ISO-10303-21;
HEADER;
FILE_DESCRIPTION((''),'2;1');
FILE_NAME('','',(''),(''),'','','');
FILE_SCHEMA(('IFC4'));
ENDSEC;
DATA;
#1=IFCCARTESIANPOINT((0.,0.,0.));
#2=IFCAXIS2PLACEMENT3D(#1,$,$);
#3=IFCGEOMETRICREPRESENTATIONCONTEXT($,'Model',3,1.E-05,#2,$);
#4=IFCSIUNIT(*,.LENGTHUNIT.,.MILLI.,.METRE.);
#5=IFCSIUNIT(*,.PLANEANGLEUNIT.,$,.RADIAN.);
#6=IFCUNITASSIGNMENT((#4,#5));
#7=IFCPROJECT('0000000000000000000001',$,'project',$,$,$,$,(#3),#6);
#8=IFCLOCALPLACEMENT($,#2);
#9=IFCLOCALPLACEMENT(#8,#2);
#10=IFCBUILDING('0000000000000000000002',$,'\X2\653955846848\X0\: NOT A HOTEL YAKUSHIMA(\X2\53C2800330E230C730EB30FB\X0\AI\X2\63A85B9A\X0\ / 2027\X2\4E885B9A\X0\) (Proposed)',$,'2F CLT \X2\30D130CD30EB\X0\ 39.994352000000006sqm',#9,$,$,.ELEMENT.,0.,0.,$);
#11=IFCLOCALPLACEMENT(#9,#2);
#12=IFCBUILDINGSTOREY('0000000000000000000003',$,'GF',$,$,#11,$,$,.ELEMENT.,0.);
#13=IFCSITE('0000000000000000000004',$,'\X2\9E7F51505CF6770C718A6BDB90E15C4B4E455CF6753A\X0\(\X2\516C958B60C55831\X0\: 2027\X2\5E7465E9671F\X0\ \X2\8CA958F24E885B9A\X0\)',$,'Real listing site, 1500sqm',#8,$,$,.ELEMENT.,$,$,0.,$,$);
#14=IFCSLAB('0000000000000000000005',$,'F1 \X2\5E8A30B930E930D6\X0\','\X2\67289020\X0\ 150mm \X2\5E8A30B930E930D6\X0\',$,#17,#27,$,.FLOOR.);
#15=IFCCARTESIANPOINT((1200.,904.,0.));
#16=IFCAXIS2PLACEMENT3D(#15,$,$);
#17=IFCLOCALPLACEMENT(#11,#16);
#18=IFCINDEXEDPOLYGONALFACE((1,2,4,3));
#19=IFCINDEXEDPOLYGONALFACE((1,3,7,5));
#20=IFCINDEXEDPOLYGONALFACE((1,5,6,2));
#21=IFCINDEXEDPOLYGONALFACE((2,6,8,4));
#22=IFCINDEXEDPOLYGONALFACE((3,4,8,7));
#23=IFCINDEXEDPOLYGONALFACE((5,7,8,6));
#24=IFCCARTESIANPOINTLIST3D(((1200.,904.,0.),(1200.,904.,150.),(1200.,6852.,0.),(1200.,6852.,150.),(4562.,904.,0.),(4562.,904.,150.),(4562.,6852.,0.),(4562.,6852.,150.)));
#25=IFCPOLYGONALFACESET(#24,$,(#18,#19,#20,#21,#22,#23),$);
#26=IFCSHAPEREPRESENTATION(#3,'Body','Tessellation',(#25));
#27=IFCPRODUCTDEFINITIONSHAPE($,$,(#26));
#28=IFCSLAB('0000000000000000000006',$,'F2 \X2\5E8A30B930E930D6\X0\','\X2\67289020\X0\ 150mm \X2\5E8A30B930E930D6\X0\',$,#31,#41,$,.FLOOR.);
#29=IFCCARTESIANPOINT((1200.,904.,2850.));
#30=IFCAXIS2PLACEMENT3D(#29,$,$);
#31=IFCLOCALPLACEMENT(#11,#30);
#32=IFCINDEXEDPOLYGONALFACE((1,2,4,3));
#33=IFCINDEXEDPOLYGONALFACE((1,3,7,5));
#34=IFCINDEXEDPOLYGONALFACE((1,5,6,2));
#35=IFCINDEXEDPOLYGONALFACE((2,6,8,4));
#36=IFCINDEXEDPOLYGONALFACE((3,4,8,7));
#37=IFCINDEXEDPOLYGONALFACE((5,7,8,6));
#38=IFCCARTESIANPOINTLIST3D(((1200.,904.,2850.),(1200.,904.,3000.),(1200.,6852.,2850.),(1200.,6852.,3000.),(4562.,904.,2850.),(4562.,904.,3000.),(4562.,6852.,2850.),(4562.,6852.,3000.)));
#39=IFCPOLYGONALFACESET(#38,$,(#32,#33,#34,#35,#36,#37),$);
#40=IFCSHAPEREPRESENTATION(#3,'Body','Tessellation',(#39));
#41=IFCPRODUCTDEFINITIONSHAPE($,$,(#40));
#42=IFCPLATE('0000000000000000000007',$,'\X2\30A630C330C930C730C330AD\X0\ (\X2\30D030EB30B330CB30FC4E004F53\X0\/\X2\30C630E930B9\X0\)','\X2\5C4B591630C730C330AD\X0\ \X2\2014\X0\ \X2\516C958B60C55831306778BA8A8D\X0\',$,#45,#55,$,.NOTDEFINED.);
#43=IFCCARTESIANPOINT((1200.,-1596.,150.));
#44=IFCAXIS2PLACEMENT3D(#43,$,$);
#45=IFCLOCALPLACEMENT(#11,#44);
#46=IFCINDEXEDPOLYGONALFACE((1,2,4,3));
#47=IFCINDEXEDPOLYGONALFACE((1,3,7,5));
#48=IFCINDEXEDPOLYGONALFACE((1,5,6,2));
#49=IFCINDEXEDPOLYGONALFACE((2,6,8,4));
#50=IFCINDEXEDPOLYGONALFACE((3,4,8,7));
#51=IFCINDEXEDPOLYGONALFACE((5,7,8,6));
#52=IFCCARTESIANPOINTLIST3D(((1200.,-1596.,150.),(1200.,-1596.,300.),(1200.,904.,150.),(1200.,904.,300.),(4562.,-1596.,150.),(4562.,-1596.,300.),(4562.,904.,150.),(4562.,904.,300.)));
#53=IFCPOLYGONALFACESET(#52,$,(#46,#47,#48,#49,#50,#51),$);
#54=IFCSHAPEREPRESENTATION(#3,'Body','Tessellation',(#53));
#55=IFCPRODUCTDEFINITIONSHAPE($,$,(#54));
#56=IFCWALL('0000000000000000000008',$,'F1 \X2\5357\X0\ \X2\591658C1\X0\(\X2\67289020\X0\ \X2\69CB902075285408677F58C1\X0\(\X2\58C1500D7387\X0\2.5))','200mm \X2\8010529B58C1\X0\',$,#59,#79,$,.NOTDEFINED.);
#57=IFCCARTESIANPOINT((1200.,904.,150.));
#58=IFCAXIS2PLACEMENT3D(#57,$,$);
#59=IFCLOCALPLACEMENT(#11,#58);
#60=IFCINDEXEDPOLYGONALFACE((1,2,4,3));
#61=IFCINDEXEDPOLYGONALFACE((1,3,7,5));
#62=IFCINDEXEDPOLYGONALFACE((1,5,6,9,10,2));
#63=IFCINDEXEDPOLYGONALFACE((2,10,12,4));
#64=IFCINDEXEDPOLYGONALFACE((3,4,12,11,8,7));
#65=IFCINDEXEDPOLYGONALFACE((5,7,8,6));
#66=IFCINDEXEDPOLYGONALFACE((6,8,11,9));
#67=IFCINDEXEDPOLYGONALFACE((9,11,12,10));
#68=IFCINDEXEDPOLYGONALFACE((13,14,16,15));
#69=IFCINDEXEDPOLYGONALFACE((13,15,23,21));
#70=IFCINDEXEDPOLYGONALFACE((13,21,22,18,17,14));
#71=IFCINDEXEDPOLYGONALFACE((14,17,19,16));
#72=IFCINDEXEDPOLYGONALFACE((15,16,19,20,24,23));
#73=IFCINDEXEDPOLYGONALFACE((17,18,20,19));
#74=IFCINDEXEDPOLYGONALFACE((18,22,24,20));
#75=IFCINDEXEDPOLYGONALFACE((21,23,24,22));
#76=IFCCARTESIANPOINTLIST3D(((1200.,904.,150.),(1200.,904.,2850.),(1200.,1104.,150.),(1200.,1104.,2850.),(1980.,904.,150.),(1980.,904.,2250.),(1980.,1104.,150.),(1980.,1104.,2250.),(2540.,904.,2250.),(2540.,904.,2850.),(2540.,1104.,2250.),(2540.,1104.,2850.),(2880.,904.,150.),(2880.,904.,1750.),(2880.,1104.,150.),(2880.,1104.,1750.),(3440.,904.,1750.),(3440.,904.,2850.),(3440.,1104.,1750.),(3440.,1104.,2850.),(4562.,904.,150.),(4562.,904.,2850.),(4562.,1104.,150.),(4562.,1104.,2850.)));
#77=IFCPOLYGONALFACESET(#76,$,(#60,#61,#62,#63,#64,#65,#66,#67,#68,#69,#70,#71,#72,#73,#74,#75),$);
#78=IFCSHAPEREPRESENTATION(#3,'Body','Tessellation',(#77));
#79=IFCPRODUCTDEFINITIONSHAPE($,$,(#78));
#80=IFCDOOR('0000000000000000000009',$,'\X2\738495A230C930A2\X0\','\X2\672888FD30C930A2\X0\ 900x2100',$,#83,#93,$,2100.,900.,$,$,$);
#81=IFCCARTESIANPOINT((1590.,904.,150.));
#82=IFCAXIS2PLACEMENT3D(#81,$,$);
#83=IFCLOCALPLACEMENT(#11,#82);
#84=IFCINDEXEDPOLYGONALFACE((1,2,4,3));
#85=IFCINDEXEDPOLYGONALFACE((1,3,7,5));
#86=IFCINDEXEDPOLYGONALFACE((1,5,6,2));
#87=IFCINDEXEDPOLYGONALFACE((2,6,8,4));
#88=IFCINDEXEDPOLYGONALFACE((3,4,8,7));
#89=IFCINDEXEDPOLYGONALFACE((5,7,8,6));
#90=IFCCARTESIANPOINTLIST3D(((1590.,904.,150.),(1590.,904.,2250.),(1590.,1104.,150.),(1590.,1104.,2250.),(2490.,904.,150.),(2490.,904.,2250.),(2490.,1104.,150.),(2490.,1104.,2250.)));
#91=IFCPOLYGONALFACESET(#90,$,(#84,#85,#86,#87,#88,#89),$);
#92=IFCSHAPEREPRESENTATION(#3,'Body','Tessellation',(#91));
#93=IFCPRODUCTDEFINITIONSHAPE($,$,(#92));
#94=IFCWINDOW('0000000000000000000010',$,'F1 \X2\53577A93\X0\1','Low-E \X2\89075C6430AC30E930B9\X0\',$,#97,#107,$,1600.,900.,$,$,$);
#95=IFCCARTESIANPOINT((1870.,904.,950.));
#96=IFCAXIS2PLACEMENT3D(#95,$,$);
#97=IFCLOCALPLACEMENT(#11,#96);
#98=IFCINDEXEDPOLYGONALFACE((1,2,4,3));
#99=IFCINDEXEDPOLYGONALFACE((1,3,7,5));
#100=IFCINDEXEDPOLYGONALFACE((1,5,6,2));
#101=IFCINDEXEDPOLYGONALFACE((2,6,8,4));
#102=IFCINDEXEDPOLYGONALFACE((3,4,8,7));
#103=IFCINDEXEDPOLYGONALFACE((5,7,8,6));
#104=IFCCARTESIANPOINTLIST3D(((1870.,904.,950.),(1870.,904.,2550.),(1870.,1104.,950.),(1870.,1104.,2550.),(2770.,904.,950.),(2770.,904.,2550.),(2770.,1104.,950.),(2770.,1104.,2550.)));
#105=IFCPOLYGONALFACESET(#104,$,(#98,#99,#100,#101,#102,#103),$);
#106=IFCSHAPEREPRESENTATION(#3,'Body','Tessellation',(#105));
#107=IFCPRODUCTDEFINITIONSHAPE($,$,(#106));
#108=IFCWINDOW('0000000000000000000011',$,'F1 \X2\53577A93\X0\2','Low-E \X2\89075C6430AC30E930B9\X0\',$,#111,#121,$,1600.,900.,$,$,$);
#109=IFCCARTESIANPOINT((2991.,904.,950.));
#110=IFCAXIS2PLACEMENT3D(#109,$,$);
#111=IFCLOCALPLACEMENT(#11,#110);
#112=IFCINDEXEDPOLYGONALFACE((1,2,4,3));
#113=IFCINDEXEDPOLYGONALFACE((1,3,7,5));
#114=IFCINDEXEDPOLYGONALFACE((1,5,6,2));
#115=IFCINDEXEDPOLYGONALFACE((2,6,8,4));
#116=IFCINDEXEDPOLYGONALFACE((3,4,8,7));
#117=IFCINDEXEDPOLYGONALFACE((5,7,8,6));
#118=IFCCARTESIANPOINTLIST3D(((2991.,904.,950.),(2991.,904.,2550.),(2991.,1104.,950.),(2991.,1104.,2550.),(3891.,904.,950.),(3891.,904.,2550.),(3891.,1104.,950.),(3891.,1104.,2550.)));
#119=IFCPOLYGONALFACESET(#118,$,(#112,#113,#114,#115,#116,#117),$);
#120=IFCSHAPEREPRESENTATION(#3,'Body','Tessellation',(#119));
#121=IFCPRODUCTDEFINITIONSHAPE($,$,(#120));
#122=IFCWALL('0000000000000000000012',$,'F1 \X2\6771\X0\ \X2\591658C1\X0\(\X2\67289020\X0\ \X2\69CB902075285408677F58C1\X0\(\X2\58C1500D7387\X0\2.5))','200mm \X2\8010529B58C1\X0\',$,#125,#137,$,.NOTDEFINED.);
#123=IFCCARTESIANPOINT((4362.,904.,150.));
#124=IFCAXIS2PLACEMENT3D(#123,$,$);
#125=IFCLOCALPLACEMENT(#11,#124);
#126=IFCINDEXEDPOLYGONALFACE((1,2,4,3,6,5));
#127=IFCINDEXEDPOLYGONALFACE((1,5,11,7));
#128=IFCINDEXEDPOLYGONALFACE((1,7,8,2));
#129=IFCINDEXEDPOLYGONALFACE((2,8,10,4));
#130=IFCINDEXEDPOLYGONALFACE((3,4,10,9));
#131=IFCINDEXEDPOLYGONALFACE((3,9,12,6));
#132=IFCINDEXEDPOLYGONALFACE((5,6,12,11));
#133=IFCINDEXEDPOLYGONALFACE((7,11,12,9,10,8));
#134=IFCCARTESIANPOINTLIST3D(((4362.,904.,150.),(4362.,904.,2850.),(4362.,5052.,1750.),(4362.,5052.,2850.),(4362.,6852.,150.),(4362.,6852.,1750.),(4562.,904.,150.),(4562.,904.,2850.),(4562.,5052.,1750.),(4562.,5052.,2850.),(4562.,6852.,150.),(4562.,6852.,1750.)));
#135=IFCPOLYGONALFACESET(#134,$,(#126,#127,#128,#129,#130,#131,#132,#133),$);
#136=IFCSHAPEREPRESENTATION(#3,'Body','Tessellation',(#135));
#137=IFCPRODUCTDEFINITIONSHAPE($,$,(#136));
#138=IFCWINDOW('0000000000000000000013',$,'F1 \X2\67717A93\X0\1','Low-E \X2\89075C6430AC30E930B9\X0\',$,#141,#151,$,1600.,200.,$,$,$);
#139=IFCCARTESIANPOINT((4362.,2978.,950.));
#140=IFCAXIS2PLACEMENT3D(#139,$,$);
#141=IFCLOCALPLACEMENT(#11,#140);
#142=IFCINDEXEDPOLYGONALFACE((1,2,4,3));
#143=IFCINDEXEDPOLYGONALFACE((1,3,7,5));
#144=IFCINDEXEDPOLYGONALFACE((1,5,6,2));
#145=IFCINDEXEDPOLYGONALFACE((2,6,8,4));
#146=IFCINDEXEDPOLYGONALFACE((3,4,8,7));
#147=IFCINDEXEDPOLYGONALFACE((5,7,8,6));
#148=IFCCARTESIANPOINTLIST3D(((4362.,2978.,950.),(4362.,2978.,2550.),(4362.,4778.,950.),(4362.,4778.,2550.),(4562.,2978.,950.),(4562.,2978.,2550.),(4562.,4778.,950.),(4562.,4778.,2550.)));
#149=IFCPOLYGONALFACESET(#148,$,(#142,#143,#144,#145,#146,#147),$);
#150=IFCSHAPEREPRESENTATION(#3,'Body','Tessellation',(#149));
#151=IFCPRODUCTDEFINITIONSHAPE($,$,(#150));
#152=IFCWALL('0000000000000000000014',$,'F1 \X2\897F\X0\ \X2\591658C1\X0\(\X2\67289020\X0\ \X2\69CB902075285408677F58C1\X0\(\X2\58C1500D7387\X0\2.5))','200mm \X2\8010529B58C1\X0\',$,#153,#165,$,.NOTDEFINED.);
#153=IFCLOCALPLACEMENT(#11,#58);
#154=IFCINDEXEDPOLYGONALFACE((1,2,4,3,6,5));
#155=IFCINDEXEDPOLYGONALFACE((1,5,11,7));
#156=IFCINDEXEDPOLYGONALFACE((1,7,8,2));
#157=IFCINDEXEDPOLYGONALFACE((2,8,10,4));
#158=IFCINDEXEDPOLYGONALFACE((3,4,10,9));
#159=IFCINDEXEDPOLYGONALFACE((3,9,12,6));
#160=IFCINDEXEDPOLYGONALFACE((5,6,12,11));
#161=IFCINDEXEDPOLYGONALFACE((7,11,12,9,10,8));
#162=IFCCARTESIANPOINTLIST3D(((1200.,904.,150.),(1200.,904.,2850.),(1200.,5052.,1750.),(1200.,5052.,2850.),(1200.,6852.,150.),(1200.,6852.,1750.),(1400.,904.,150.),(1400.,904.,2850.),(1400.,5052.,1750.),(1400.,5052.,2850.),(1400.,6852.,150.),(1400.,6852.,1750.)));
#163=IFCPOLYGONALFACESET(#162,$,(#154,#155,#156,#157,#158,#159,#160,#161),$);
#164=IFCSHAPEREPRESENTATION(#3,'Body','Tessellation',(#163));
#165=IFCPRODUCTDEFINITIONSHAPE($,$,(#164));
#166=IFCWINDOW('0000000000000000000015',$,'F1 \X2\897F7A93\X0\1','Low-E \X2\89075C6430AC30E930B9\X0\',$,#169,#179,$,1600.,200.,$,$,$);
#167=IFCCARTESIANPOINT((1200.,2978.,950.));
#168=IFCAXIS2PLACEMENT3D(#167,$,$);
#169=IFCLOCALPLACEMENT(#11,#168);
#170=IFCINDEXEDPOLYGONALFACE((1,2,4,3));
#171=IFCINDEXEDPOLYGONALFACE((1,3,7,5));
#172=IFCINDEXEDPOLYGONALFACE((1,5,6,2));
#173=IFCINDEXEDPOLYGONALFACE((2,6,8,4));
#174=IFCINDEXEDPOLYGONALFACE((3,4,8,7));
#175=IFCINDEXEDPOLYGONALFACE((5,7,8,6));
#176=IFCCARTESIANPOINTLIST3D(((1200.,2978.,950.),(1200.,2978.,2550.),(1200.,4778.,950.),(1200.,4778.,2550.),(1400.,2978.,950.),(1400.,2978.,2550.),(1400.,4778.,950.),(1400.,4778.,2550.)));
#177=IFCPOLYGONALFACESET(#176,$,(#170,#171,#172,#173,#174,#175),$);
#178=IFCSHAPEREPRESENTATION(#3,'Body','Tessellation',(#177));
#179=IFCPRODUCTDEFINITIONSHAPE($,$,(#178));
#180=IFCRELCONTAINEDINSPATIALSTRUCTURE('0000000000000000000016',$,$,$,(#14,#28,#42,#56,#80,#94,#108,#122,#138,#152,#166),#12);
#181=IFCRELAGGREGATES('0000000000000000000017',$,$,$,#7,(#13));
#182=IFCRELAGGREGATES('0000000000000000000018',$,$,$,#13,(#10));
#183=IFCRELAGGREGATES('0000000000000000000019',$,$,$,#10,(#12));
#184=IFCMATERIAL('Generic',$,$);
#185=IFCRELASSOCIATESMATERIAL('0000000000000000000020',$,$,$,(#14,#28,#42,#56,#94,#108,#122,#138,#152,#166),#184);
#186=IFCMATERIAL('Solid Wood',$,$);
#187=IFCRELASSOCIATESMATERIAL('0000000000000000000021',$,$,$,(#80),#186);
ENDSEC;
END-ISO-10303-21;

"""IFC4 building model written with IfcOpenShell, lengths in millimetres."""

from ifc_helpers import new_model, si_unit, frame, frame_2d, origin, place, context, project, spatial, rectangle, extrude, material, element, fill, save


model = new_model("IFC4")

# Units and contexts
model_context = context("Model", 3, precision=1e-05, world=origin())
ifc_project = project(units=[si_unit("LENGTHUNIT", "METRE", prefix="MILLI"), si_unit("PLANEANGLEUNIT", "RADIAN")], contexts=[model_context])

# Site, building, storey
site_placement = place(None, origin())
site = spatial("IfcSite", under=ifc_project, at=site_placement, Name="鹿児島県熊毛郡屋久島町(公開情報: 2027年早期 販売予定)", ObjectType="Real listing site, 1500sqm", CompositionType="ELEMENT", RefElevation=0.0)
building_placement = place(site_placement, origin())
building = spatial("IfcBuilding", under=site, at=building_placement, Name="改善案: NOT A HOTEL YAKUSHIMA(参考モデル・AI推定 / 2027予定) (Proposed)", ObjectType="2F CLT パネル 39.994352000000006sqm", CompositionType="ELEMENT", ElevationOfRefHeight=0.0, ElevationOfTerrain=0.0)
storey_placement = place(building_placement, origin())
storey = spatial("IfcBuildingStorey", under=building, at=storey_placement, Name="GF", CompositionType="ELEMENT", Elevation=0.0)

# Slabs
ifc_material_1 = material(Name="Generic")
slab_1_placement = place(storey_placement, frame((1200.0, 904.0, 0.0)))
element("IfcSlab", 1, at=slab_1_placement, inside=storey, material=ifc_material_1, Name="F1 床スラブ", Description="木造 150mm 床スラブ", PredefinedType="FLOOR", context=model_context, shape_type="SweptSolid", body=[
    extrude(rectangle(XDim=3362.0, YDim=5948.0, at=frame_2d((1681.0, 2974.0))), frame((1200.0, 904.0, 0.0)), (0.0, 0.0, 1.0), 150.0),
])
slab_2_placement = place(storey_placement, frame((1200.0, 904.0, 2850.0)))
element("IfcSlab", 2, at=slab_2_placement, inside=storey, material=ifc_material_1, Name="F2 床スラブ", Description="木造 150mm 床スラブ", PredefinedType="FLOOR", context=model_context, shape_type="SweptSolid", body=[
    extrude(rectangle(XDim=3362.0, YDim=5948.0, at=frame_2d((1681.0, 2974.0))), frame((1200.0, 904.0, 2850.0)), (0.0, 0.0, 1.0), 150.0),
])

# Plate
plate_placement = place(storey_placement, frame((1200.0, -1596.0, 150.0)))
element("IfcPlate", 3, at=plate_placement, inside=storey, material=ifc_material_1, Name="ウッドデッキ (バルコニー一体/テラス)", Description="屋外デッキ — 公開情報で確認", PredefinedType="NOTDEFINED", context=model_context, shape_type="SweptSolid", body=[
    extrude(rectangle(XDim=3362.0, YDim=2500.0, at=frame_2d((1681.0, 1250.0))), frame((1200.0, -1596.0, 150.0)), (0.0, 0.0, 1.0), 150.0),
])

# Wall, openings, door, windows
wall_1_placement = place(storey_placement, frame((1200.0, 904.0, 150.0)))
wall_1 = element("IfcWall", 4, at=wall_1_placement, inside=storey, material=ifc_material_1, Name="F1 南 外壁(木造 構造用合板壁(壁倍率2.5))", Description="200mm 耐力壁", PredefinedType="NOTDEFINED", context=model_context, shape_type="SweptSolid", body=[
    extrude(rectangle(XDim=3362.0, YDim=200.0, at=frame_2d((1681.0, 100.0))), frame((1200.0, 904.0, 150.0)), (0.0, 0.0, 1.0), 2700.0),
])
opening_1_placement = place(storey_placement, frame((1590.0, 904.0, 150.0)))
opening_1 = element("IfcOpeningElement", 5, at=opening_1_placement, cuts=wall_1, PredefinedType="NOTDEFINED", context=model_context, shape_type="SweptSolid", body=[
    extrude(rectangle(XDim=900.0, YDim=200.0, at=frame_2d((450.0, 100.0))), frame((1590.0, 904.0, 150.0)), (0.0, 0.0, 1.0), 2100.0),
])
opening_2_placement = place(storey_placement, frame((1870.0, 904.0, 950.0)))
opening_2 = element("IfcOpeningElement", 6, at=opening_2_placement, cuts=wall_1, PredefinedType="NOTDEFINED", context=model_context, shape_type="SweptSolid", body=[
    extrude(rectangle(XDim=900.0, YDim=200.0, at=frame_2d((450.0, 100.0))), frame((1870.0, 904.0, 950.0)), (0.0, 0.0, 1.0), 1600.0),
])
opening_3_placement = place(storey_placement, frame((2991.0, 904.0, 950.0)))
opening_3 = element("IfcOpeningElement", 7, at=opening_3_placement, cuts=wall_1, PredefinedType="NOTDEFINED", context=model_context, shape_type="SweptSolid", body=[
    extrude(rectangle(XDim=900.0, YDim=200.0, at=frame_2d((450.0, 100.0))), frame((2991.0, 904.0, 950.0)), (0.0, 0.0, 1.0), 1600.0),
])
ifc_material_2 = material(Name="Solid Wood")
door_placement = place(storey_placement, frame((1590.0, 904.0, 150.0)))
door = element("IfcDoor", 8, at=door_placement, inside=storey, material=ifc_material_2, Name="玄関ドア", Description="木製ドア 900x2100", OverallHeight=2100.0, OverallWidth=900.0, context=model_context, shape_type="SweptSolid", body=[
    extrude(rectangle(XDim=900.0, YDim=200.0, at=frame_2d((450.0, 100.0))), frame((1590.0, 904.0, 150.0)), (0.0, 0.0, 1.0), 2100.0),
])
fill(opening_1, door)
window_1_placement = place(storey_placement, frame((1870.0, 904.0, 950.0)))
window_1 = element("IfcWindow", 9, at=window_1_placement, inside=storey, material=ifc_material_1, Name="F1 南窓1", Description="Low-E 複層ガラス", OverallHeight=1600.0, OverallWidth=900.0, context=model_context, shape_type="SweptSolid", body=[
    extrude(rectangle(XDim=900.0, YDim=200.0, at=frame_2d((450.0, 100.0))), frame((1870.0, 904.0, 950.0)), (0.0, 0.0, 1.0), 1600.0),
])
fill(opening_2, window_1)
window_2_placement = place(storey_placement, frame((2991.0, 904.0, 950.0)))
window_2 = element("IfcWindow", 10, at=window_2_placement, inside=storey, material=ifc_material_1, Name="F1 南窓2", Description="Low-E 複層ガラス", OverallHeight=1600.0, OverallWidth=900.0, context=model_context, shape_type="SweptSolid", body=[
    extrude(rectangle(XDim=900.0, YDim=200.0, at=frame_2d((450.0, 100.0))), frame((2991.0, 904.0, 950.0)), (0.0, 0.0, 1.0), 1600.0),
])
fill(opening_3, window_2)

# Walls, openings, windows
wall_2_placement = place(storey_placement, frame((4362.0, 904.0, 150.0)))
wall_2 = element("IfcWall", 11, at=wall_2_placement, inside=storey, material=ifc_material_1, Name="F1 東 外壁(木造 構造用合板壁(壁倍率2.5))", Description="200mm 耐力壁", PredefinedType="NOTDEFINED", context=model_context, shape_type="SweptSolid", body=[
    extrude(rectangle(XDim=200.0, YDim=5948.0, at=frame_2d((100.0, 2974.0))), frame((4362.0, 904.0, 150.0)), (0.0, 0.0, 1.0), 2700.0),
])
opening_4_placement = place(storey_placement, frame((4362.0, 2978.0, 950.0)))
opening_4 = element("IfcOpeningElement", 12, at=opening_4_placement, cuts=wall_2, PredefinedType="NOTDEFINED", context=model_context, shape_type="SweptSolid", body=[
    extrude(rectangle(XDim=200.0, YDim=1800.0, at=frame_2d((100.0, 900.0))), frame((4362.0, 2978.0, 950.0)), (0.0, 0.0, 1.0), 1600.0),
])
window_3_placement = place(storey_placement, frame((4362.0, 2978.0, 950.0)))
window_3 = element("IfcWindow", 13, at=window_3_placement, inside=storey, material=ifc_material_1, Name="F1 東窓1", Description="Low-E 複層ガラス", OverallHeight=1600.0, OverallWidth=200.0, context=model_context, shape_type="SweptSolid", body=[
    extrude(rectangle(XDim=200.0, YDim=1800.0, at=frame_2d((100.0, 900.0))), frame((4362.0, 2978.0, 950.0)), (0.0, 0.0, 1.0), 1600.0),
])
fill(opening_4, window_3)
wall_3_placement = place(storey_placement, frame((1200.0, 904.0, 150.0)))
wall_3 = element("IfcWall", 14, at=wall_3_placement, inside=storey, material=ifc_material_1, Name="F1 西 外壁(木造 構造用合板壁(壁倍率2.5))", Description="200mm 耐力壁", PredefinedType="NOTDEFINED", context=model_context, shape_type="SweptSolid", body=[
    extrude(rectangle(XDim=200.0, YDim=5948.0, at=frame_2d((100.0, 2974.0))), frame((1200.0, 904.0, 150.0)), (0.0, 0.0, 1.0), 2700.0),
])
opening_5_placement = place(storey_placement, frame((1200.0, 2978.0, 950.0)))
opening_5 = element("IfcOpeningElement", 15, at=opening_5_placement, cuts=wall_3, PredefinedType="NOTDEFINED", context=model_context, shape_type="SweptSolid", body=[
    extrude(rectangle(XDim=200.0, YDim=1800.0, at=frame_2d((100.0, 900.0))), frame((1200.0, 2978.0, 950.0)), (0.0, 0.0, 1.0), 1600.0),
])
window_4_placement = place(storey_placement, frame((1200.0, 2978.0, 950.0)))
window_4 = element("IfcWindow", 16, at=window_4_placement, inside=storey, material=ifc_material_1, Name="F1 西窓1", Description="Low-E 複層ガラス", OverallHeight=1600.0, OverallWidth=200.0, context=model_context, shape_type="SweptSolid", body=[
    extrude(rectangle(XDim=200.0, YDim=1800.0, at=frame_2d((100.0, 900.0))), frame((1200.0, 2978.0, 950.0)), (0.0, 0.0, 1.0), 1600.0),
])
fill(opening_5, window_4)

save(model, "model.ifc")
